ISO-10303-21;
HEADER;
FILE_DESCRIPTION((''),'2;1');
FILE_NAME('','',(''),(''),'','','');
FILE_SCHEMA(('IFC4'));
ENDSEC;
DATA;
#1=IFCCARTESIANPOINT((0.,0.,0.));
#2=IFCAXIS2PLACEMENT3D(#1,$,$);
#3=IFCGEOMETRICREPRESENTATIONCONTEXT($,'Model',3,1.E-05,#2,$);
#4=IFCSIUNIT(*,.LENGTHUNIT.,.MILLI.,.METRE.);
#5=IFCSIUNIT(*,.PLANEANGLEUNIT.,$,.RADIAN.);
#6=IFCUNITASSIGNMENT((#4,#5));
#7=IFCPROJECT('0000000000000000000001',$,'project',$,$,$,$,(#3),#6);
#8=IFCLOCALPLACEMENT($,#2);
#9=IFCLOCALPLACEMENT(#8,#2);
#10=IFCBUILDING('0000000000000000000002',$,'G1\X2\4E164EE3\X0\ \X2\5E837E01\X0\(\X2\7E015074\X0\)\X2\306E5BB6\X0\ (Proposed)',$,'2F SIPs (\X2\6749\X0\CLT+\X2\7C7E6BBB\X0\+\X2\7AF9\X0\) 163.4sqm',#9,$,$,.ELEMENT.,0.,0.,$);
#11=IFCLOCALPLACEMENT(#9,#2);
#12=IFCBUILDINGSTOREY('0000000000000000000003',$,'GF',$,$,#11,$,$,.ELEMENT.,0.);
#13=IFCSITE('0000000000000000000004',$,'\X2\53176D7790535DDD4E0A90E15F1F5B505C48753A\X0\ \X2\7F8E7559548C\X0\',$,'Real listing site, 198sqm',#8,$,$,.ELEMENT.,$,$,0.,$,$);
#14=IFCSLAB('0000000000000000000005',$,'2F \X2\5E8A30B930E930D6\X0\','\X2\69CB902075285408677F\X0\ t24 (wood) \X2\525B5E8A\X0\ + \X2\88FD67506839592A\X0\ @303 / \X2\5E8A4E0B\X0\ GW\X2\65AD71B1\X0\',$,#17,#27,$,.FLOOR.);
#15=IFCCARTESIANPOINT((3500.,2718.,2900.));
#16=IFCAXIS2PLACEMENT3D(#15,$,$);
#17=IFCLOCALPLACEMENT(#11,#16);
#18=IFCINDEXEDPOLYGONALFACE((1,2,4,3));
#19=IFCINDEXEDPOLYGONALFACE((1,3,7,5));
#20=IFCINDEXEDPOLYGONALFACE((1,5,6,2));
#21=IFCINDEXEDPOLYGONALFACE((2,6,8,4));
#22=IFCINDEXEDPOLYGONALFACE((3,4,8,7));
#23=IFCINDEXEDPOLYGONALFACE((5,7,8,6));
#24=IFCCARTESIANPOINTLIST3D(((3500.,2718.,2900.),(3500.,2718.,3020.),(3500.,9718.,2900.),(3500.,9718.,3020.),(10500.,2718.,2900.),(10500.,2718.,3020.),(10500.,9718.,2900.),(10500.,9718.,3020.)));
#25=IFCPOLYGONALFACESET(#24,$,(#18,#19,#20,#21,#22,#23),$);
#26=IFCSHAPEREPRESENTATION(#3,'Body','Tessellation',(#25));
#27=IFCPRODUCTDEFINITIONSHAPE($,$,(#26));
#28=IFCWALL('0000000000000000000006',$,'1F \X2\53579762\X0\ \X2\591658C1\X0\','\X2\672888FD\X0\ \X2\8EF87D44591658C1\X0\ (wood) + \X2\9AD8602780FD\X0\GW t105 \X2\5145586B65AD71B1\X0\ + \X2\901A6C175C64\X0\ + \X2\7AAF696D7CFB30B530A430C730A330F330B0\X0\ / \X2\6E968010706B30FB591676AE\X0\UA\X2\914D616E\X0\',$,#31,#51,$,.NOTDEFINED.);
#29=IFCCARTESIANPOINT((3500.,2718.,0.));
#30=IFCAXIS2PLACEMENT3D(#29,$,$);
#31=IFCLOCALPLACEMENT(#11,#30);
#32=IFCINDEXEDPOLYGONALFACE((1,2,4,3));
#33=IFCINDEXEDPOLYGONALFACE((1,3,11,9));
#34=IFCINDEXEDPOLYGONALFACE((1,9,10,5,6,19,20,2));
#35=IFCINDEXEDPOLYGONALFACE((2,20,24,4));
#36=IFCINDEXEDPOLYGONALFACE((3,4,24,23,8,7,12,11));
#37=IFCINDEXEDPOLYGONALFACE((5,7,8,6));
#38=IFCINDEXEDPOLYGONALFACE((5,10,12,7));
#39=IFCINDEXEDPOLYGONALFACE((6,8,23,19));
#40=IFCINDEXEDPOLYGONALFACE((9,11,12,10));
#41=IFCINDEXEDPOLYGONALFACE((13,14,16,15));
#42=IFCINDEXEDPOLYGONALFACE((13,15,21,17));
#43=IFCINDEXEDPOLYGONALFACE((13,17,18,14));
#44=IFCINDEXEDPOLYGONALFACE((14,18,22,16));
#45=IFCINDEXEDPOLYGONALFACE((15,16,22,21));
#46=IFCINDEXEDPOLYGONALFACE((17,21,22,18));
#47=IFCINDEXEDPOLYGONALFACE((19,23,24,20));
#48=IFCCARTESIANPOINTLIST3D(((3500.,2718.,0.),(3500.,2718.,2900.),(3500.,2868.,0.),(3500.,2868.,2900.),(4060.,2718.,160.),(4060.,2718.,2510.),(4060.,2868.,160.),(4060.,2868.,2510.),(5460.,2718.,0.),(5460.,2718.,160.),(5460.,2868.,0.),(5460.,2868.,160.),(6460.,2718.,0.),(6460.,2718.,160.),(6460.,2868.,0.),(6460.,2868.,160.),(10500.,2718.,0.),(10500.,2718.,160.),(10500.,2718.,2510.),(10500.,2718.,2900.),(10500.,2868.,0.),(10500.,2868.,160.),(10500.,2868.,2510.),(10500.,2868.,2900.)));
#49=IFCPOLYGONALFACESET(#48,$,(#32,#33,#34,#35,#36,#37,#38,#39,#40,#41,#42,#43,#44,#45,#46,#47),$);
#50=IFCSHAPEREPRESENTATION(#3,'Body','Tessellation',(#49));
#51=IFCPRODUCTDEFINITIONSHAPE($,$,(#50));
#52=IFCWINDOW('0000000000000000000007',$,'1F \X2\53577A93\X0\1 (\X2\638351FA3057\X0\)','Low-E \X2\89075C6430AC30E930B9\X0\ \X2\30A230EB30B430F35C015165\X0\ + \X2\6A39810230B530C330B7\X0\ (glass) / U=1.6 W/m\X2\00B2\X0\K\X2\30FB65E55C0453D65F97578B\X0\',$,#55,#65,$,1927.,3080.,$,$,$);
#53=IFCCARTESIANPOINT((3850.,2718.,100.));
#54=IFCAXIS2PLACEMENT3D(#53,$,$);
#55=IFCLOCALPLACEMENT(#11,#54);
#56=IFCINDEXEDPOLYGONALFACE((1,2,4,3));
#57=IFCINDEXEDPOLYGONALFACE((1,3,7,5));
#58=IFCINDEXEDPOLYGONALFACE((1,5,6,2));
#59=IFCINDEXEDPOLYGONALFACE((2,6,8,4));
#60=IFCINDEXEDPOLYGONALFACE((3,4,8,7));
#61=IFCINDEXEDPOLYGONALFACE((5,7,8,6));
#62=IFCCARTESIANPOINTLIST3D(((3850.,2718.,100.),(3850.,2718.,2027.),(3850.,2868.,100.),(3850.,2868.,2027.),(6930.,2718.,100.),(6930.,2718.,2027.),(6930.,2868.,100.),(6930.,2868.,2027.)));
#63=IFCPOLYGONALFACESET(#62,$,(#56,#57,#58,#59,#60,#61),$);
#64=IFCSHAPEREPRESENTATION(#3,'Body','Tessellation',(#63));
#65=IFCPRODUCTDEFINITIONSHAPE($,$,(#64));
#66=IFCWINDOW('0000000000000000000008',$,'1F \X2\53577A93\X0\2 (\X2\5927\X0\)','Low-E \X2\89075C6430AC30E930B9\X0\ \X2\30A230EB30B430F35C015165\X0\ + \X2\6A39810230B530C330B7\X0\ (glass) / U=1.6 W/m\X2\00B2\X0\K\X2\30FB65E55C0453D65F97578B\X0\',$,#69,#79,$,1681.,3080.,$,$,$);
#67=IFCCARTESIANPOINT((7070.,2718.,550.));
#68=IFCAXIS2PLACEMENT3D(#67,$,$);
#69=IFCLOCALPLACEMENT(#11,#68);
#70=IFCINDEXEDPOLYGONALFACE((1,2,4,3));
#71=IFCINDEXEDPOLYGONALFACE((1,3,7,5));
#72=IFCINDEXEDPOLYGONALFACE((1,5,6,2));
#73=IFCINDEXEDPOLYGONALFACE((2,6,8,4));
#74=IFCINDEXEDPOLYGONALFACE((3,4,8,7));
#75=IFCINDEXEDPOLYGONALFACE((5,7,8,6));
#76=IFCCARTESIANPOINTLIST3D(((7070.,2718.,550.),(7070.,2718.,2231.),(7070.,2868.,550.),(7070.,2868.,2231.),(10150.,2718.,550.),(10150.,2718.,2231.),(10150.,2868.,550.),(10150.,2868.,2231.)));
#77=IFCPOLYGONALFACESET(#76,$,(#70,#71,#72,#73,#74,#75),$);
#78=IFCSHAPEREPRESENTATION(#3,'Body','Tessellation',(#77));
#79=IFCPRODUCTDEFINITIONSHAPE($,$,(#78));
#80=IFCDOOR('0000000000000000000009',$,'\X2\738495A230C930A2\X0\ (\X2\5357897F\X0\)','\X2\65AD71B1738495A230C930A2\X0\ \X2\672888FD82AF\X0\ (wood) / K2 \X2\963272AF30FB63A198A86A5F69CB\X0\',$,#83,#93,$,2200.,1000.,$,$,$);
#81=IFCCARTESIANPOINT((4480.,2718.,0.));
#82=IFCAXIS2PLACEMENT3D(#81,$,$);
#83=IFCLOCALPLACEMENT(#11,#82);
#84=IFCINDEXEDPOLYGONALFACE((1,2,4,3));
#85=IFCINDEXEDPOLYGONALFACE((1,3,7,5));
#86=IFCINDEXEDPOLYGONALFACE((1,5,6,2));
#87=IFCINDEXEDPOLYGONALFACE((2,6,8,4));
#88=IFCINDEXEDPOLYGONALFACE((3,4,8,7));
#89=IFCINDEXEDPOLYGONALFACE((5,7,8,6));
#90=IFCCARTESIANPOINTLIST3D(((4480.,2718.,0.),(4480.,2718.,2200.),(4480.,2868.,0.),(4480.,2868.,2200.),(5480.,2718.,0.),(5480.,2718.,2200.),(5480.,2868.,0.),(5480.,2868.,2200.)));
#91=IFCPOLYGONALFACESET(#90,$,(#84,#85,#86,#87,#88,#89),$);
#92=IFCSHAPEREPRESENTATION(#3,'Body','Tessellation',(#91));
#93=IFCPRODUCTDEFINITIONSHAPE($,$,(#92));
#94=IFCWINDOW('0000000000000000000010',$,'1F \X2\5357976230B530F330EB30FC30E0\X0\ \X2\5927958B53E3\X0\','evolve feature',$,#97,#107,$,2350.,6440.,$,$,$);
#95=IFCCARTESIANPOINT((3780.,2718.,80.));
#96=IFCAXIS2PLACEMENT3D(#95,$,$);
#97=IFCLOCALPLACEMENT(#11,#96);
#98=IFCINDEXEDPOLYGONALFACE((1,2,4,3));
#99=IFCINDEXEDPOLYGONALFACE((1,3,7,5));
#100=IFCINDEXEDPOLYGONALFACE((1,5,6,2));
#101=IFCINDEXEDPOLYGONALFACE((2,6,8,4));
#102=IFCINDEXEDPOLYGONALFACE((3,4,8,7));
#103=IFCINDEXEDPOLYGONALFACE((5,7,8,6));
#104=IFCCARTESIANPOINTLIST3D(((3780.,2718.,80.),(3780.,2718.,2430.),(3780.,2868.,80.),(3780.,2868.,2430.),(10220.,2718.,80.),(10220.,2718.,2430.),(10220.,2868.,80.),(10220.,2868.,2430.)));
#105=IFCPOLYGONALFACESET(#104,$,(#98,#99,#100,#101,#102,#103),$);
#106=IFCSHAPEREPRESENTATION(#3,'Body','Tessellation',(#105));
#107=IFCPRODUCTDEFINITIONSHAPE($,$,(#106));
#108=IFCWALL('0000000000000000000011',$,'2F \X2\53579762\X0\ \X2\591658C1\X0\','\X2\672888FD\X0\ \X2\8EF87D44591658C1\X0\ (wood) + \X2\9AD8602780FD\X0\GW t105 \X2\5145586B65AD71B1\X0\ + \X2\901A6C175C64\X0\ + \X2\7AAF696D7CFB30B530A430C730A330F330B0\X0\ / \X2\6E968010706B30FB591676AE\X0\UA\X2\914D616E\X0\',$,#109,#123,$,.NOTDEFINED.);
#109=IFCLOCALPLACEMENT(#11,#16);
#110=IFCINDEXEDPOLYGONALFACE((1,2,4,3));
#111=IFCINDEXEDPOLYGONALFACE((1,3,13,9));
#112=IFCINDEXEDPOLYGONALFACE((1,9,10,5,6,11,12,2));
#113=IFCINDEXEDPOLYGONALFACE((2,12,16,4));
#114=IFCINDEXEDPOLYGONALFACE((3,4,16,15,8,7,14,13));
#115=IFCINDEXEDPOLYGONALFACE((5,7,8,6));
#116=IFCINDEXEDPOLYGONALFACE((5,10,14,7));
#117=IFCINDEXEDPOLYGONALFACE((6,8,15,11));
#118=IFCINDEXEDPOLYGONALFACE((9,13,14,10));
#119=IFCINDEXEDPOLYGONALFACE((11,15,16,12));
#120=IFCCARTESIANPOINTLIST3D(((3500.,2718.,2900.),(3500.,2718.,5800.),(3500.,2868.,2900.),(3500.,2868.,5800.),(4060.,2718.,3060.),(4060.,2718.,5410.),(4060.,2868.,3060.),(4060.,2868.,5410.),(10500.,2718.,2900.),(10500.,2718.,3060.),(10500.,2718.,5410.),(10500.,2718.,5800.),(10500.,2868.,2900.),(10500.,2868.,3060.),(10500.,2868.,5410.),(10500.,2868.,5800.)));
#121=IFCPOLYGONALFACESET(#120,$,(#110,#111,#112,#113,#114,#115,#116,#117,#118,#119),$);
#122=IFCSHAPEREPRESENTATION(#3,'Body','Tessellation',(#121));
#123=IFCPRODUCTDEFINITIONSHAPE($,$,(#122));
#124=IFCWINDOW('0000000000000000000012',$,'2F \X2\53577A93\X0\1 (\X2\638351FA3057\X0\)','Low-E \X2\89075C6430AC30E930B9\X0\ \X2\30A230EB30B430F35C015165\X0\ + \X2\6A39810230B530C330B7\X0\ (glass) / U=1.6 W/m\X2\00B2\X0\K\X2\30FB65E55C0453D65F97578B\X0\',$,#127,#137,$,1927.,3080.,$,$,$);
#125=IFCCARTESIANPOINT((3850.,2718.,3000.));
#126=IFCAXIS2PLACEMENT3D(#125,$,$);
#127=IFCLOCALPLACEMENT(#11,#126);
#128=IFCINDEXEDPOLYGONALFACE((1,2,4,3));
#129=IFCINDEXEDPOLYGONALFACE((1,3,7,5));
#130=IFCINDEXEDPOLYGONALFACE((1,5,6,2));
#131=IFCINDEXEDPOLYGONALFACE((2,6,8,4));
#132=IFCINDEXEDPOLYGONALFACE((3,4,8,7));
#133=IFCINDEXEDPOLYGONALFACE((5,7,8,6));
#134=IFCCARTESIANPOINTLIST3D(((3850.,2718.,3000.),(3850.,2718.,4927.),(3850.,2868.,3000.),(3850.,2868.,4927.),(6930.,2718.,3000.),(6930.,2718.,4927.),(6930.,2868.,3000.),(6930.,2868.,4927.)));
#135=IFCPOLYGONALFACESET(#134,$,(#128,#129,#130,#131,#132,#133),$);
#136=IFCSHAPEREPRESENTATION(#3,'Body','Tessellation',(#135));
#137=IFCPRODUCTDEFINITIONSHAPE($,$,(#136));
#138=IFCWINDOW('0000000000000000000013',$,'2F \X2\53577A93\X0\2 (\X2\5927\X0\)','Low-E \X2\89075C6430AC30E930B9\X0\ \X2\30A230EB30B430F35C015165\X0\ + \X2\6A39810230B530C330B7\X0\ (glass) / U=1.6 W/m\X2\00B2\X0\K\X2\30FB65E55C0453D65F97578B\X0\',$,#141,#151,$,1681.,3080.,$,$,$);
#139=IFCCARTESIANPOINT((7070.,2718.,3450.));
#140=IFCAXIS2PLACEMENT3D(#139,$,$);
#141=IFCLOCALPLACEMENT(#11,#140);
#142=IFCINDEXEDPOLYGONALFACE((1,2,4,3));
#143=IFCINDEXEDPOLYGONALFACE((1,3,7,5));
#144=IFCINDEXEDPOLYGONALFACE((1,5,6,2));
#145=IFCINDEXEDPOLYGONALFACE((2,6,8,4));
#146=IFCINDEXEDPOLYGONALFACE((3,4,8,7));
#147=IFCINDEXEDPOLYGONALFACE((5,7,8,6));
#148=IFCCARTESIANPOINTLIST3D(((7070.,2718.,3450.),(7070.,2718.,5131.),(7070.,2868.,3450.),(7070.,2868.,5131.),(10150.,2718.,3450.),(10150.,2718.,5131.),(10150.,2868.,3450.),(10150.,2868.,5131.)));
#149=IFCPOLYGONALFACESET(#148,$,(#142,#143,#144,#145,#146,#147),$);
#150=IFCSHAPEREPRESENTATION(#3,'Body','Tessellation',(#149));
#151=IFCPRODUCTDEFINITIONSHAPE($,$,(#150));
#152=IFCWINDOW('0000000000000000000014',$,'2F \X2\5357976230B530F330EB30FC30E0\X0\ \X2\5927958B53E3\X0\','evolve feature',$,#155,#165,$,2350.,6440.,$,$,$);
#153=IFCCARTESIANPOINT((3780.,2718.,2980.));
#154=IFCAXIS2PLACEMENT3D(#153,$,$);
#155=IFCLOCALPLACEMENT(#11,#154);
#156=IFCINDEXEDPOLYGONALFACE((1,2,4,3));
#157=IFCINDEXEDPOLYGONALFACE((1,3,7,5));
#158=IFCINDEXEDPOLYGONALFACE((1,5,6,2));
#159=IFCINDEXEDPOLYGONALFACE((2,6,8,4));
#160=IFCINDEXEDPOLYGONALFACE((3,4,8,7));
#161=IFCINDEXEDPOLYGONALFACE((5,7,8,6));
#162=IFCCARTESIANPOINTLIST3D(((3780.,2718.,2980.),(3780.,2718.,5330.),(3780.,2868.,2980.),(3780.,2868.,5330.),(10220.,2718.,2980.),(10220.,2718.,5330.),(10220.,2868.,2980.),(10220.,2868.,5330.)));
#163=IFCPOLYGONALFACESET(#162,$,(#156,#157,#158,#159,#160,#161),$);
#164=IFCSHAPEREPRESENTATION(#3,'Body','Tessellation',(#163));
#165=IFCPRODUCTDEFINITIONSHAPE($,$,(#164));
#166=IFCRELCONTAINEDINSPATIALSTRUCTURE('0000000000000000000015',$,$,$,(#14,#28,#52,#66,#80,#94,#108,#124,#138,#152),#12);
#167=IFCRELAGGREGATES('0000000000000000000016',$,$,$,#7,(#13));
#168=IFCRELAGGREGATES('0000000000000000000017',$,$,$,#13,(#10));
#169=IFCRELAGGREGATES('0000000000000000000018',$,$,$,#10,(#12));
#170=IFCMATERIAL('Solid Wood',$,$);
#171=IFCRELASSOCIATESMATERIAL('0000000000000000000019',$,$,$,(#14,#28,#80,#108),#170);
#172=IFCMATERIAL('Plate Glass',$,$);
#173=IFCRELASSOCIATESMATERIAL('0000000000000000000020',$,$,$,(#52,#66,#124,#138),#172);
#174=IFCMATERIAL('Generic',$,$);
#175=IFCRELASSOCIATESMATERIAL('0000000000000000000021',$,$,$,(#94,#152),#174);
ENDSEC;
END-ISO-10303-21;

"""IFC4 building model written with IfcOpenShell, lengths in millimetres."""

from ifc_helpers import new_model, si_unit, frame, frame_2d, origin, place, context, project, spatial, rectangle, extrude, material, element, fill, save


model = new_model("IFC4")

# Units and contexts
model_context = context("Model", 3, precision=1e-05, world=origin())
ifc_project = project(units=[si_unit("LENGTHUNIT", "METRE", prefix="MILLI"), si_unit("PLANEANGLEUNIT", "RADIAN")], contexts=[model_context])

# Site, building, storey
site_placement = place(None, origin())
site = spatial("IfcSite", under=ifc_project, at=site_placement, Name="北海道川上郡弟子屈町 美留和", ObjectType="Real listing site, 198sqm", CompositionType="ELEMENT", RefElevation=0.0)
building_placement = place(site_placement, origin())
building = spatial("IfcBuilding", under=site, at=building_placement, Name="G1世代 広縁(縁側)の家 (Proposed)", ObjectType="2F SIPs (杉CLT+籾殻+竹) 163.4sqm", CompositionType="ELEMENT", ElevationOfRefHeight=0.0, ElevationOfTerrain=0.0)
storey_placement = place(building_placement, origin())
storey = spatial("IfcBuildingStorey", under=building, at=storey_placement, Name="GF", CompositionType="ELEMENT", Elevation=0.0)

# Slab
ifc_material_1 = material(Name="Solid Wood")
slab_1_placement = place(storey_placement, frame((3500.0, 2718.0, 2900.0)))
element("IfcSlab", 1, at=slab_1_placement, inside=storey, material=ifc_material_1, Name="2F 床スラブ", Description="構造用合板 t24 (wood) 剛床 + 製材根太 @303 / 床下 GW断熱", PredefinedType="FLOOR", context=model_context, shape_type="SweptSolid", body=[
    extrude(rectangle(XDim=7000.0, YDim=7000.0, at=frame_2d((3500.0, 3500.0))), frame((3500.0, 2718.0, 2900.0)), (0.0, 0.0, 1.0), 120.0),
])
ifc_material_2 = material(Name="Generic")

# Wall, openings, windows, door
wall_1_placement = place(storey_placement, frame((3500.0, 2718.0, 0.0)))
wall_1 = element("IfcWall", 2, at=wall_1_placement, inside=storey, material=ifc_material_1, Name="1F 南面 外壁", Description="木製 軸組外壁 (wood) + 高性能GW t105 充填断熱 + 通気層 + 窯業系サイディング / 準耐火・外皮UA配慮", PredefinedType="NOTDEFINED", context=model_context, shape_type="SweptSolid", body=[
    extrude(rectangle(XDim=7000.0, YDim=150.0, at=frame_2d((3500.0, 75.0))), frame((3500.0, 2718.0, 0.0)), (0.0, 0.0, 1.0), 2900.0),
])
opening_1_placement = place(storey_placement, frame((3850.0, 2718.0, 100.0)))
opening_1 = element("IfcOpeningElement", 3, at=opening_1_placement, cuts=wall_1, PredefinedType="NOTDEFINED", context=model_context, shape_type="SweptSolid", body=[
    extrude(rectangle(XDim=3080.0, YDim=150.0, at=frame_2d((1540.0, 75.0))), frame((3850.0, 2718.0, 100.0)), (0.0, 0.0, 1.0), 1927.0),
])
opening_2_placement = place(storey_placement, frame((7070.0, 2718.0, 550.0)))
opening_2 = element("IfcOpeningElement", 4, at=opening_2_placement, cuts=wall_1, PredefinedType="NOTDEFINED", context=model_context, shape_type="SweptSolid", body=[
    extrude(rectangle(XDim=3080.0, YDim=150.0, at=frame_2d((1540.0, 75.0))), frame((7070.0, 2718.0, 550.0)), (0.0, 0.0, 1.0), 1681.0),
])
opening_3_placement = place(storey_placement, frame((4480.0, 2718.0, 0.0)))
opening_3 = element("IfcOpeningElement", 5, at=opening_3_placement, cuts=wall_1, PredefinedType="NOTDEFINED", context=model_context, shape_type="SweptSolid", body=[
    extrude(rectangle(XDim=1000.0, YDim=150.0, at=frame_2d((500.0, 75.0))), frame((4480.0, 2718.0, 0.0)), (0.0, 0.0, 1.0), 2200.0),
])
opening_4_placement = place(storey_placement, frame((3780.0, 2718.0, 80.0)))
opening_4 = element("IfcOpeningElement", 6, at=opening_4_placement, cuts=wall_1, PredefinedType="NOTDEFINED", context=model_context, shape_type="SweptSolid", body=[
    extrude(rectangle(XDim=6440.0, YDim=150.0, at=frame_2d((3220.0, 75.0))), frame((3780.0, 2718.0, 80.0)), (0.0, 0.0, 1.0), 2350.0),
])
ifc_material_3 = material(Name="Plate Glass")
window_1_placement = place(storey_placement, frame((3850.0, 2718.0, 100.0)))
window_1 = element("IfcWindow", 7, at=window_1_placement, inside=storey, material=ifc_material_3, Name="1F 南窓1 (掃出し)", Description="Low-E 複層ガラス アルゴン封入 + 樹脂サッシ (glass) / U=1.6 W/m²K・日射取得型", OverallHeight=1927.0, OverallWidth=3080.0, context=model_context, shape_type="SweptSolid", body=[
    extrude(rectangle(XDim=3080.0, YDim=150.0, at=frame_2d((1540.0, 75.0))), frame((3850.0, 2718.0, 100.0)), (0.0, 0.0, 1.0), 1927.0),
])
fill(opening_1, window_1)
window_2_placement = place(storey_placement, frame((7070.0, 2718.0, 550.0)))
window_2 = element("IfcWindow", 8, at=window_2_placement, inside=storey, material=ifc_material_3, Name="1F 南窓2 (大)", Description="Low-E 複層ガラス アルゴン封入 + 樹脂サッシ (glass) / U=1.6 W/m²K・日射取得型", OverallHeight=1681.0, OverallWidth=3080.0, context=model_context, shape_type="SweptSolid", body=[
    extrude(rectangle(XDim=3080.0, YDim=150.0, at=frame_2d((1540.0, 75.0))), frame((7070.0, 2718.0, 550.0)), (0.0, 0.0, 1.0), 1681.0),
])
fill(opening_2, window_2)
door_placement = place(storey_placement, frame((4480.0, 2718.0, 0.0)))
door = element("IfcDoor", 9, at=door_placement, inside=storey, material=ifc_material_1, Name="玄関ドア (南西)", Description="断熱玄関ドア 木製芯 (wood) / K2 防犯・採風機構", OverallHeight=2200.0, OverallWidth=1000.0, context=model_context, shape_type="SweptSolid", body=[
    extrude(rectangle(XDim=1000.0, YDim=150.0, at=frame_2d((500.0, 75.0))), frame((4480.0, 2718.0, 0.0)), (0.0, 0.0, 1.0), 2200.0),
])
fill(opening_3, door)
window_3_placement = place(storey_placement, frame((3780.0, 2718.0, 80.0)))
window_3 = element("IfcWindow", 10, at=window_3_placement, inside=storey, material=ifc_material_2, Name="1F 南面サンルーム 大開口", Description="evolve feature", OverallHeight=2350.0, OverallWidth=6440.0, context=model_context, shape_type="SweptSolid", body=[
    extrude(rectangle(XDim=6440.0, YDim=150.0, at=frame_2d((3220.0, 75.0))), frame((3780.0, 2718.0, 80.0)), (0.0, 0.0, 1.0), 2350.0),
])
fill(opening_4, window_3)

# Wall, openings, windows
wall_2_placement = place(storey_placement, frame((3500.0, 2718.0, 2900.0)))
wall_2 = element("IfcWall", 11, at=wall_2_placement, inside=storey, material=ifc_material_1, Name="2F 南面 外壁", Description="木製 軸組外壁 (wood) + 高性能GW t105 充填断熱 + 通気層 + 窯業系サイディング / 準耐火・外皮UA配慮", PredefinedType="NOTDEFINED", context=model_context, shape_type="SweptSolid", body=[
    extrude(rectangle(XDim=7000.0, YDim=150.0, at=frame_2d((3500.0, 75.0))), frame((3500.0, 2718.0, 2900.0)), (0.0, 0.0, 1.0), 2900.0),
])
opening_5_placement = place(storey_placement, frame((3850.0, 2718.0, 3000.0)))
opening_5 = element("IfcOpeningElement", 12, at=opening_5_placement, cuts=wall_2, PredefinedType="NOTDEFINED", context=model_context, shape_type="SweptSolid", body=[
    extrude(rectangle(XDim=3080.0, YDim=150.0, at=frame_2d((1540.0, 75.0))), frame((3850.0, 2718.0, 3000.0)), (0.0, 0.0, 1.0), 1927.0),
])
opening_6_placement = place(storey_placement, frame((7070.0, 2718.0, 3450.0)))
opening_6 = element("IfcOpeningElement", 13, at=opening_6_placement, cuts=wall_2, PredefinedType="NOTDEFINED", context=model_context, shape_type="SweptSolid", body=[
    extrude(rectangle(XDim=3080.0, YDim=150.0, at=frame_2d((1540.0, 75.0))), frame((7070.0, 2718.0, 3450.0)), (0.0, 0.0, 1.0), 1681.0),
])
opening_7_placement = place(storey_placement, frame((3780.0, 2718.0, 2980.0)))
opening_7 = element("IfcOpeningElement", 14, at=opening_7_placement, cuts=wall_2, PredefinedType="NOTDEFINED", context=model_context, shape_type="SweptSolid", body=[
    extrude(rectangle(XDim=6440.0, YDim=150.0, at=frame_2d((3220.0, 75.0))), frame((3780.0, 2718.0, 2980.0)), (0.0, 0.0, 1.0), 2350.0),
])
window_4_placement = place(storey_placement, frame((3850.0, 2718.0, 3000.0)))
window_4 = element("IfcWindow", 15, at=window_4_placement, inside=storey, material=ifc_material_3, Name="2F 南窓1 (掃出し)", Description="Low-E 複層ガラス アルゴン封入 + 樹脂サッシ (glass) / U=1.6 W/m²K・日射取得型", OverallHeight=1927.0, OverallWidth=3080.0, context=model_context, shape_type="SweptSolid", body=[
    extrude(rectangle(XDim=3080.0, YDim=150.0, at=frame_2d((1540.0, 75.0))), frame((3850.0, 2718.0, 3000.0)), (0.0, 0.0, 1.0), 1927.0),
])
fill(opening_5, window_4)
window_5_placement = place(storey_placement, frame((7070.0, 2718.0, 3450.0)))
window_5 = element("IfcWindow", 16, at=window_5_placement, inside=storey, material=ifc_material_3, Name="2F 南窓2 (大)", Description="Low-E 複層ガラス アルゴン封入 + 樹脂サッシ (glass) / U=1.6 W/m²K・日射取得型", OverallHeight=1681.0, OverallWidth=3080.0, context=model_context, shape_type="SweptSolid", body=[
    extrude(rectangle(XDim=3080.0, YDim=150.0, at=frame_2d((1540.0, 75.0))), frame((7070.0, 2718.0, 3450.0)), (0.0, 0.0, 1.0), 1681.0),
])
fill(opening_6, window_5)
window_6_placement = place(storey_placement, frame((3780.0, 2718.0, 2980.0)))
window_6 = element("IfcWindow", 17, at=window_6_placement, inside=storey, material=ifc_material_2, Name="2F 南面サンルーム 大開口", Description="evolve feature", OverallHeight=2350.0, OverallWidth=6440.0, context=model_context, shape_type="SweptSolid", body=[
    extrude(rectangle(XDim=6440.0, YDim=150.0, at=frame_2d((3220.0, 75.0))), frame((3780.0, 2718.0, 2980.0)), (0.0, 0.0, 1.0), 2350.0),
])
fill(opening_7, window_6)

save(model, "model.ifc")
